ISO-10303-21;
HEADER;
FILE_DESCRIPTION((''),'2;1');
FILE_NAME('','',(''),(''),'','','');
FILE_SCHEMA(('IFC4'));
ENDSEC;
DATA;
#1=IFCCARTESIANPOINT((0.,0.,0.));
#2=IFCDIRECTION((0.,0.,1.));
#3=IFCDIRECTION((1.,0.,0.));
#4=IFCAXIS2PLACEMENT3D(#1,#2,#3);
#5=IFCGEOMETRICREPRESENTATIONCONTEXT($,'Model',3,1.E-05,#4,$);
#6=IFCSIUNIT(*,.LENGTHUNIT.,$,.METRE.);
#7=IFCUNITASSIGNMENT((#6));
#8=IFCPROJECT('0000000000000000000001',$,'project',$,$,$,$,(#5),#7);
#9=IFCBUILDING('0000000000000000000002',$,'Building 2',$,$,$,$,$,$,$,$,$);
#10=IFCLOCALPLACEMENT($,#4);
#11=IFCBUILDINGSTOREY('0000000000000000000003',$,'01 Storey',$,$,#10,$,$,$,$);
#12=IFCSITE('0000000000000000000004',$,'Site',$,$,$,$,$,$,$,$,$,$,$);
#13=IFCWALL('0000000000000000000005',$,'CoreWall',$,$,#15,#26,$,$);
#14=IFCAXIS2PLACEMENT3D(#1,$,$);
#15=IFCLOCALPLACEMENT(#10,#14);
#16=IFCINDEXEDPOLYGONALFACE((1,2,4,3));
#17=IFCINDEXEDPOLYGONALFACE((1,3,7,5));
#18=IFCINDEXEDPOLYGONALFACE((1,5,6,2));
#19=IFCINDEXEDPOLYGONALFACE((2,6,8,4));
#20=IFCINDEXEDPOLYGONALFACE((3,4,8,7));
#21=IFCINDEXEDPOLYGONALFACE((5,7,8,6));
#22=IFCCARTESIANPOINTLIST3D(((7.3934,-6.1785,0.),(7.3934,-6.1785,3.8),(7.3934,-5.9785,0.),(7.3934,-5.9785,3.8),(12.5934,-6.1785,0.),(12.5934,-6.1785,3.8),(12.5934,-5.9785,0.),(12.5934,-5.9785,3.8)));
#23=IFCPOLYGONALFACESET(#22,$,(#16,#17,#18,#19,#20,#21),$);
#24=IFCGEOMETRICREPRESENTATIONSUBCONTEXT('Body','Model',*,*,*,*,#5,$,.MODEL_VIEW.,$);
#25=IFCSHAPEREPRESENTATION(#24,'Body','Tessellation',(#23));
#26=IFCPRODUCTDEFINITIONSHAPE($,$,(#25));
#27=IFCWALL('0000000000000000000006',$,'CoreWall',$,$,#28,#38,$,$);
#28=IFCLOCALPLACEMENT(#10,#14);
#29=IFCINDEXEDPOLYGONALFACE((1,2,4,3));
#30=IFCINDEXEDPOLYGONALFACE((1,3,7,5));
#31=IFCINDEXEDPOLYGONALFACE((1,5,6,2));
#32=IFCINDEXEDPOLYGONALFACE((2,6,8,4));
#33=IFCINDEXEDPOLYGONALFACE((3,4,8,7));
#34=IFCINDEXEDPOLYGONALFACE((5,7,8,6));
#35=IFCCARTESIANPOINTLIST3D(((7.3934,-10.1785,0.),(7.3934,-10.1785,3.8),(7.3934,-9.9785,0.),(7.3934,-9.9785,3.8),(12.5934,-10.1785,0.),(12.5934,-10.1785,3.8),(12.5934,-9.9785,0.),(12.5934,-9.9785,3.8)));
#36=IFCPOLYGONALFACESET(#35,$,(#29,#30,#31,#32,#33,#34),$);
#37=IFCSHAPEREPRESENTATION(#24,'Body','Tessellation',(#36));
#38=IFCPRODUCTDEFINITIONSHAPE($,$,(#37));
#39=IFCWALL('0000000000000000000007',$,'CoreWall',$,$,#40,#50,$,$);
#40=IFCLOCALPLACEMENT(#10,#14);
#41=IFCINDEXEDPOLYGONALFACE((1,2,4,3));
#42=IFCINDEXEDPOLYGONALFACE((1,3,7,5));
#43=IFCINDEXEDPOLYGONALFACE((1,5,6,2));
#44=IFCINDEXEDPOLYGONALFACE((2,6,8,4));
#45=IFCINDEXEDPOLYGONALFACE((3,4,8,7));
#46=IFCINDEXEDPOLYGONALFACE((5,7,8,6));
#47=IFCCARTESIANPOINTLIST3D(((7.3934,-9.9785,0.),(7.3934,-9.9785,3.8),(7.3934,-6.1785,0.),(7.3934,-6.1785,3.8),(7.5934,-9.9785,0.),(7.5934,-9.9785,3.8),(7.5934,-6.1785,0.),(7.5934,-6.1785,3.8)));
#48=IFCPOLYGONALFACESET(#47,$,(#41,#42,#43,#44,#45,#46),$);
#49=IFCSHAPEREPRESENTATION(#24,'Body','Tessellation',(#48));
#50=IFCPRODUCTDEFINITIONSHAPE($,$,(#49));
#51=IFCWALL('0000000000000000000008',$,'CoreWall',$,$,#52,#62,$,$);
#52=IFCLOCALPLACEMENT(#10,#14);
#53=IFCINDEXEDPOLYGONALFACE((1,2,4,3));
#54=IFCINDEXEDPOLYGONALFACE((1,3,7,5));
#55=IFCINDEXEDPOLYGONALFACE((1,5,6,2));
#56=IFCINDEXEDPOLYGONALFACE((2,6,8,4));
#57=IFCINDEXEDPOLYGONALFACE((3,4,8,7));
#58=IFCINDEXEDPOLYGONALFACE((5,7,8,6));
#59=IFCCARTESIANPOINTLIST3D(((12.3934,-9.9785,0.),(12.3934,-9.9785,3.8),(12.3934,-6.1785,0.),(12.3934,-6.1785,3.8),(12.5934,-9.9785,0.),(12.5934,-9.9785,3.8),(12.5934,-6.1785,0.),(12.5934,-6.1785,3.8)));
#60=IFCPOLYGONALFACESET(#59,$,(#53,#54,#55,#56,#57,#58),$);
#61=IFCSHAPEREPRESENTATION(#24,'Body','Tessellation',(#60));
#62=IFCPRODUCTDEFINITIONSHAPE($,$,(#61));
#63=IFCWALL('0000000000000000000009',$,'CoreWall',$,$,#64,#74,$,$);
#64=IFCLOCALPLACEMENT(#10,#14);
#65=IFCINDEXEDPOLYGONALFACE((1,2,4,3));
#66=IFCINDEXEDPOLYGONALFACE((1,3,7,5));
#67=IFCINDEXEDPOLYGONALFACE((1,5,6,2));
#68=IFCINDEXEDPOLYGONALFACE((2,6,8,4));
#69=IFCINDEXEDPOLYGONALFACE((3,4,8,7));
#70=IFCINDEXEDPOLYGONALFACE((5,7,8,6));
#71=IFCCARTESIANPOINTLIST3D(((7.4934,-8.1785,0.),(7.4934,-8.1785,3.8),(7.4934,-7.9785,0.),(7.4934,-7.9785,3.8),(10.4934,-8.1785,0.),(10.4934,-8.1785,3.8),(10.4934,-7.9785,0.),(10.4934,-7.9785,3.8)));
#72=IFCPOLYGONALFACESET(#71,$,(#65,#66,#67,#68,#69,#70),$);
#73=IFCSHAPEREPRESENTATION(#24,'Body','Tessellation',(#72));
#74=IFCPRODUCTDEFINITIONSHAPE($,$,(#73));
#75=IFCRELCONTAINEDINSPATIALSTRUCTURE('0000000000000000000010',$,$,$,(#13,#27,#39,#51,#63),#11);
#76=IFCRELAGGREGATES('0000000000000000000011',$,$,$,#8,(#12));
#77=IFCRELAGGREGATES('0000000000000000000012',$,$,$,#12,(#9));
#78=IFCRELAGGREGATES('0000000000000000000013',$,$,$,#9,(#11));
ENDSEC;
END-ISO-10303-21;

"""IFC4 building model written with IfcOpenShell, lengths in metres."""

from ifc_helpers import new_model, si_unit, origin_with_axes, place, context, subcontext, project, spatial, line, indexed_curve, outline, extrude, element, save


model = new_model("IFC4")

# Units and contexts
model_context = context("Model", 3, precision=1e-05, world=origin_with_axes())
body_context = subcontext(model_context, "Body", "Model", "MODEL_VIEW")
ifc_project = project(units=[si_unit("LENGTHUNIT", "METRE")], contexts=[model_context])

# Site, building, storey
site = spatial("IfcSite", under=ifc_project, Name="Site")
building = spatial("IfcBuilding", under=site, Name="Building 2")
storey_placement = place(None, origin_with_axes())
storey = spatial("IfcBuildingStorey", under=building, at=storey_placement, Name="01 Storey")

# Walls
wall_1_placement = place(storey_placement, origin_with_axes())
element("IfcWall", 1, at=wall_1_placement, inside=storey, Name="CoreWall", context=body_context, shape_type="SweptSolid", body=[
    extrude(outline(indexed_curve([(12.5934, -5.9785), (7.3934, -5.9785), (7.3934, -6.1785), (12.5934, -6.1785)], segments=[line(1, 2), line(2, 3), line(3, 4)])), origin_with_axes(), (0.0, 0.0, 1.0), 3.8),
])
wall_2_placement = place(storey_placement, origin_with_axes())
element("IfcWall", 2, at=wall_2_placement, inside=storey, Name="CoreWall", context=body_context, shape_type="SweptSolid", body=[
    extrude(outline(indexed_curve([(7.3934, -10.1785), (12.5934, -10.1785), (12.5934, -9.9785), (7.3934, -9.9785)], segments=[line(1, 2), line(2, 3), line(3, 4)])), origin_with_axes(), (0.0, 0.0, 1.0), 3.8),
])
wall_3_placement = place(storey_placement, origin_with_axes())
element("IfcWall", 3, at=wall_3_placement, inside=storey, Name="CoreWall", context=body_context, shape_type="SweptSolid", body=[
    extrude(outline(indexed_curve([(7.5934, -9.9785), (7.5934, -6.1785), (7.3934, -6.1785), (7.3934, -9.9785)], segments=[line(1, 2), line(2, 3), line(3, 4)])), origin_with_axes(), (0.0, 0.0, 1.0), 3.8),
])
wall_4_placement = place(storey_placement, origin_with_axes())
element("IfcWall", 4, at=wall_4_placement, inside=storey, Name="CoreWall", context=body_context, shape_type="SweptSolid", body=[
    extrude(outline(indexed_curve([(12.3934, -6.1785), (12.3934, -9.9785), (12.5934, -9.9785), (12.5934, -6.1785)], segments=[line(1, 2), line(2, 3), line(3, 4)])), origin_with_axes(), (0.0, 0.0, 1.0), 3.8),
])
wall_5_placement = place(storey_placement, origin_with_axes())
element("IfcWall", 5, at=wall_5_placement, inside=storey, Name="CoreWall", context=body_context, shape_type="SweptSolid", body=[
    extrude(outline(indexed_curve([(10.4934, -7.9785), (7.4934, -7.9785), (7.4934, -8.1785), (10.4934, -8.1785)], segments=[line(1, 2), line(2, 3), line(3, 4)])), origin_with_axes(), (0.0, 0.0, 1.0), 3.8),
])

save(model, "model.ifc")
